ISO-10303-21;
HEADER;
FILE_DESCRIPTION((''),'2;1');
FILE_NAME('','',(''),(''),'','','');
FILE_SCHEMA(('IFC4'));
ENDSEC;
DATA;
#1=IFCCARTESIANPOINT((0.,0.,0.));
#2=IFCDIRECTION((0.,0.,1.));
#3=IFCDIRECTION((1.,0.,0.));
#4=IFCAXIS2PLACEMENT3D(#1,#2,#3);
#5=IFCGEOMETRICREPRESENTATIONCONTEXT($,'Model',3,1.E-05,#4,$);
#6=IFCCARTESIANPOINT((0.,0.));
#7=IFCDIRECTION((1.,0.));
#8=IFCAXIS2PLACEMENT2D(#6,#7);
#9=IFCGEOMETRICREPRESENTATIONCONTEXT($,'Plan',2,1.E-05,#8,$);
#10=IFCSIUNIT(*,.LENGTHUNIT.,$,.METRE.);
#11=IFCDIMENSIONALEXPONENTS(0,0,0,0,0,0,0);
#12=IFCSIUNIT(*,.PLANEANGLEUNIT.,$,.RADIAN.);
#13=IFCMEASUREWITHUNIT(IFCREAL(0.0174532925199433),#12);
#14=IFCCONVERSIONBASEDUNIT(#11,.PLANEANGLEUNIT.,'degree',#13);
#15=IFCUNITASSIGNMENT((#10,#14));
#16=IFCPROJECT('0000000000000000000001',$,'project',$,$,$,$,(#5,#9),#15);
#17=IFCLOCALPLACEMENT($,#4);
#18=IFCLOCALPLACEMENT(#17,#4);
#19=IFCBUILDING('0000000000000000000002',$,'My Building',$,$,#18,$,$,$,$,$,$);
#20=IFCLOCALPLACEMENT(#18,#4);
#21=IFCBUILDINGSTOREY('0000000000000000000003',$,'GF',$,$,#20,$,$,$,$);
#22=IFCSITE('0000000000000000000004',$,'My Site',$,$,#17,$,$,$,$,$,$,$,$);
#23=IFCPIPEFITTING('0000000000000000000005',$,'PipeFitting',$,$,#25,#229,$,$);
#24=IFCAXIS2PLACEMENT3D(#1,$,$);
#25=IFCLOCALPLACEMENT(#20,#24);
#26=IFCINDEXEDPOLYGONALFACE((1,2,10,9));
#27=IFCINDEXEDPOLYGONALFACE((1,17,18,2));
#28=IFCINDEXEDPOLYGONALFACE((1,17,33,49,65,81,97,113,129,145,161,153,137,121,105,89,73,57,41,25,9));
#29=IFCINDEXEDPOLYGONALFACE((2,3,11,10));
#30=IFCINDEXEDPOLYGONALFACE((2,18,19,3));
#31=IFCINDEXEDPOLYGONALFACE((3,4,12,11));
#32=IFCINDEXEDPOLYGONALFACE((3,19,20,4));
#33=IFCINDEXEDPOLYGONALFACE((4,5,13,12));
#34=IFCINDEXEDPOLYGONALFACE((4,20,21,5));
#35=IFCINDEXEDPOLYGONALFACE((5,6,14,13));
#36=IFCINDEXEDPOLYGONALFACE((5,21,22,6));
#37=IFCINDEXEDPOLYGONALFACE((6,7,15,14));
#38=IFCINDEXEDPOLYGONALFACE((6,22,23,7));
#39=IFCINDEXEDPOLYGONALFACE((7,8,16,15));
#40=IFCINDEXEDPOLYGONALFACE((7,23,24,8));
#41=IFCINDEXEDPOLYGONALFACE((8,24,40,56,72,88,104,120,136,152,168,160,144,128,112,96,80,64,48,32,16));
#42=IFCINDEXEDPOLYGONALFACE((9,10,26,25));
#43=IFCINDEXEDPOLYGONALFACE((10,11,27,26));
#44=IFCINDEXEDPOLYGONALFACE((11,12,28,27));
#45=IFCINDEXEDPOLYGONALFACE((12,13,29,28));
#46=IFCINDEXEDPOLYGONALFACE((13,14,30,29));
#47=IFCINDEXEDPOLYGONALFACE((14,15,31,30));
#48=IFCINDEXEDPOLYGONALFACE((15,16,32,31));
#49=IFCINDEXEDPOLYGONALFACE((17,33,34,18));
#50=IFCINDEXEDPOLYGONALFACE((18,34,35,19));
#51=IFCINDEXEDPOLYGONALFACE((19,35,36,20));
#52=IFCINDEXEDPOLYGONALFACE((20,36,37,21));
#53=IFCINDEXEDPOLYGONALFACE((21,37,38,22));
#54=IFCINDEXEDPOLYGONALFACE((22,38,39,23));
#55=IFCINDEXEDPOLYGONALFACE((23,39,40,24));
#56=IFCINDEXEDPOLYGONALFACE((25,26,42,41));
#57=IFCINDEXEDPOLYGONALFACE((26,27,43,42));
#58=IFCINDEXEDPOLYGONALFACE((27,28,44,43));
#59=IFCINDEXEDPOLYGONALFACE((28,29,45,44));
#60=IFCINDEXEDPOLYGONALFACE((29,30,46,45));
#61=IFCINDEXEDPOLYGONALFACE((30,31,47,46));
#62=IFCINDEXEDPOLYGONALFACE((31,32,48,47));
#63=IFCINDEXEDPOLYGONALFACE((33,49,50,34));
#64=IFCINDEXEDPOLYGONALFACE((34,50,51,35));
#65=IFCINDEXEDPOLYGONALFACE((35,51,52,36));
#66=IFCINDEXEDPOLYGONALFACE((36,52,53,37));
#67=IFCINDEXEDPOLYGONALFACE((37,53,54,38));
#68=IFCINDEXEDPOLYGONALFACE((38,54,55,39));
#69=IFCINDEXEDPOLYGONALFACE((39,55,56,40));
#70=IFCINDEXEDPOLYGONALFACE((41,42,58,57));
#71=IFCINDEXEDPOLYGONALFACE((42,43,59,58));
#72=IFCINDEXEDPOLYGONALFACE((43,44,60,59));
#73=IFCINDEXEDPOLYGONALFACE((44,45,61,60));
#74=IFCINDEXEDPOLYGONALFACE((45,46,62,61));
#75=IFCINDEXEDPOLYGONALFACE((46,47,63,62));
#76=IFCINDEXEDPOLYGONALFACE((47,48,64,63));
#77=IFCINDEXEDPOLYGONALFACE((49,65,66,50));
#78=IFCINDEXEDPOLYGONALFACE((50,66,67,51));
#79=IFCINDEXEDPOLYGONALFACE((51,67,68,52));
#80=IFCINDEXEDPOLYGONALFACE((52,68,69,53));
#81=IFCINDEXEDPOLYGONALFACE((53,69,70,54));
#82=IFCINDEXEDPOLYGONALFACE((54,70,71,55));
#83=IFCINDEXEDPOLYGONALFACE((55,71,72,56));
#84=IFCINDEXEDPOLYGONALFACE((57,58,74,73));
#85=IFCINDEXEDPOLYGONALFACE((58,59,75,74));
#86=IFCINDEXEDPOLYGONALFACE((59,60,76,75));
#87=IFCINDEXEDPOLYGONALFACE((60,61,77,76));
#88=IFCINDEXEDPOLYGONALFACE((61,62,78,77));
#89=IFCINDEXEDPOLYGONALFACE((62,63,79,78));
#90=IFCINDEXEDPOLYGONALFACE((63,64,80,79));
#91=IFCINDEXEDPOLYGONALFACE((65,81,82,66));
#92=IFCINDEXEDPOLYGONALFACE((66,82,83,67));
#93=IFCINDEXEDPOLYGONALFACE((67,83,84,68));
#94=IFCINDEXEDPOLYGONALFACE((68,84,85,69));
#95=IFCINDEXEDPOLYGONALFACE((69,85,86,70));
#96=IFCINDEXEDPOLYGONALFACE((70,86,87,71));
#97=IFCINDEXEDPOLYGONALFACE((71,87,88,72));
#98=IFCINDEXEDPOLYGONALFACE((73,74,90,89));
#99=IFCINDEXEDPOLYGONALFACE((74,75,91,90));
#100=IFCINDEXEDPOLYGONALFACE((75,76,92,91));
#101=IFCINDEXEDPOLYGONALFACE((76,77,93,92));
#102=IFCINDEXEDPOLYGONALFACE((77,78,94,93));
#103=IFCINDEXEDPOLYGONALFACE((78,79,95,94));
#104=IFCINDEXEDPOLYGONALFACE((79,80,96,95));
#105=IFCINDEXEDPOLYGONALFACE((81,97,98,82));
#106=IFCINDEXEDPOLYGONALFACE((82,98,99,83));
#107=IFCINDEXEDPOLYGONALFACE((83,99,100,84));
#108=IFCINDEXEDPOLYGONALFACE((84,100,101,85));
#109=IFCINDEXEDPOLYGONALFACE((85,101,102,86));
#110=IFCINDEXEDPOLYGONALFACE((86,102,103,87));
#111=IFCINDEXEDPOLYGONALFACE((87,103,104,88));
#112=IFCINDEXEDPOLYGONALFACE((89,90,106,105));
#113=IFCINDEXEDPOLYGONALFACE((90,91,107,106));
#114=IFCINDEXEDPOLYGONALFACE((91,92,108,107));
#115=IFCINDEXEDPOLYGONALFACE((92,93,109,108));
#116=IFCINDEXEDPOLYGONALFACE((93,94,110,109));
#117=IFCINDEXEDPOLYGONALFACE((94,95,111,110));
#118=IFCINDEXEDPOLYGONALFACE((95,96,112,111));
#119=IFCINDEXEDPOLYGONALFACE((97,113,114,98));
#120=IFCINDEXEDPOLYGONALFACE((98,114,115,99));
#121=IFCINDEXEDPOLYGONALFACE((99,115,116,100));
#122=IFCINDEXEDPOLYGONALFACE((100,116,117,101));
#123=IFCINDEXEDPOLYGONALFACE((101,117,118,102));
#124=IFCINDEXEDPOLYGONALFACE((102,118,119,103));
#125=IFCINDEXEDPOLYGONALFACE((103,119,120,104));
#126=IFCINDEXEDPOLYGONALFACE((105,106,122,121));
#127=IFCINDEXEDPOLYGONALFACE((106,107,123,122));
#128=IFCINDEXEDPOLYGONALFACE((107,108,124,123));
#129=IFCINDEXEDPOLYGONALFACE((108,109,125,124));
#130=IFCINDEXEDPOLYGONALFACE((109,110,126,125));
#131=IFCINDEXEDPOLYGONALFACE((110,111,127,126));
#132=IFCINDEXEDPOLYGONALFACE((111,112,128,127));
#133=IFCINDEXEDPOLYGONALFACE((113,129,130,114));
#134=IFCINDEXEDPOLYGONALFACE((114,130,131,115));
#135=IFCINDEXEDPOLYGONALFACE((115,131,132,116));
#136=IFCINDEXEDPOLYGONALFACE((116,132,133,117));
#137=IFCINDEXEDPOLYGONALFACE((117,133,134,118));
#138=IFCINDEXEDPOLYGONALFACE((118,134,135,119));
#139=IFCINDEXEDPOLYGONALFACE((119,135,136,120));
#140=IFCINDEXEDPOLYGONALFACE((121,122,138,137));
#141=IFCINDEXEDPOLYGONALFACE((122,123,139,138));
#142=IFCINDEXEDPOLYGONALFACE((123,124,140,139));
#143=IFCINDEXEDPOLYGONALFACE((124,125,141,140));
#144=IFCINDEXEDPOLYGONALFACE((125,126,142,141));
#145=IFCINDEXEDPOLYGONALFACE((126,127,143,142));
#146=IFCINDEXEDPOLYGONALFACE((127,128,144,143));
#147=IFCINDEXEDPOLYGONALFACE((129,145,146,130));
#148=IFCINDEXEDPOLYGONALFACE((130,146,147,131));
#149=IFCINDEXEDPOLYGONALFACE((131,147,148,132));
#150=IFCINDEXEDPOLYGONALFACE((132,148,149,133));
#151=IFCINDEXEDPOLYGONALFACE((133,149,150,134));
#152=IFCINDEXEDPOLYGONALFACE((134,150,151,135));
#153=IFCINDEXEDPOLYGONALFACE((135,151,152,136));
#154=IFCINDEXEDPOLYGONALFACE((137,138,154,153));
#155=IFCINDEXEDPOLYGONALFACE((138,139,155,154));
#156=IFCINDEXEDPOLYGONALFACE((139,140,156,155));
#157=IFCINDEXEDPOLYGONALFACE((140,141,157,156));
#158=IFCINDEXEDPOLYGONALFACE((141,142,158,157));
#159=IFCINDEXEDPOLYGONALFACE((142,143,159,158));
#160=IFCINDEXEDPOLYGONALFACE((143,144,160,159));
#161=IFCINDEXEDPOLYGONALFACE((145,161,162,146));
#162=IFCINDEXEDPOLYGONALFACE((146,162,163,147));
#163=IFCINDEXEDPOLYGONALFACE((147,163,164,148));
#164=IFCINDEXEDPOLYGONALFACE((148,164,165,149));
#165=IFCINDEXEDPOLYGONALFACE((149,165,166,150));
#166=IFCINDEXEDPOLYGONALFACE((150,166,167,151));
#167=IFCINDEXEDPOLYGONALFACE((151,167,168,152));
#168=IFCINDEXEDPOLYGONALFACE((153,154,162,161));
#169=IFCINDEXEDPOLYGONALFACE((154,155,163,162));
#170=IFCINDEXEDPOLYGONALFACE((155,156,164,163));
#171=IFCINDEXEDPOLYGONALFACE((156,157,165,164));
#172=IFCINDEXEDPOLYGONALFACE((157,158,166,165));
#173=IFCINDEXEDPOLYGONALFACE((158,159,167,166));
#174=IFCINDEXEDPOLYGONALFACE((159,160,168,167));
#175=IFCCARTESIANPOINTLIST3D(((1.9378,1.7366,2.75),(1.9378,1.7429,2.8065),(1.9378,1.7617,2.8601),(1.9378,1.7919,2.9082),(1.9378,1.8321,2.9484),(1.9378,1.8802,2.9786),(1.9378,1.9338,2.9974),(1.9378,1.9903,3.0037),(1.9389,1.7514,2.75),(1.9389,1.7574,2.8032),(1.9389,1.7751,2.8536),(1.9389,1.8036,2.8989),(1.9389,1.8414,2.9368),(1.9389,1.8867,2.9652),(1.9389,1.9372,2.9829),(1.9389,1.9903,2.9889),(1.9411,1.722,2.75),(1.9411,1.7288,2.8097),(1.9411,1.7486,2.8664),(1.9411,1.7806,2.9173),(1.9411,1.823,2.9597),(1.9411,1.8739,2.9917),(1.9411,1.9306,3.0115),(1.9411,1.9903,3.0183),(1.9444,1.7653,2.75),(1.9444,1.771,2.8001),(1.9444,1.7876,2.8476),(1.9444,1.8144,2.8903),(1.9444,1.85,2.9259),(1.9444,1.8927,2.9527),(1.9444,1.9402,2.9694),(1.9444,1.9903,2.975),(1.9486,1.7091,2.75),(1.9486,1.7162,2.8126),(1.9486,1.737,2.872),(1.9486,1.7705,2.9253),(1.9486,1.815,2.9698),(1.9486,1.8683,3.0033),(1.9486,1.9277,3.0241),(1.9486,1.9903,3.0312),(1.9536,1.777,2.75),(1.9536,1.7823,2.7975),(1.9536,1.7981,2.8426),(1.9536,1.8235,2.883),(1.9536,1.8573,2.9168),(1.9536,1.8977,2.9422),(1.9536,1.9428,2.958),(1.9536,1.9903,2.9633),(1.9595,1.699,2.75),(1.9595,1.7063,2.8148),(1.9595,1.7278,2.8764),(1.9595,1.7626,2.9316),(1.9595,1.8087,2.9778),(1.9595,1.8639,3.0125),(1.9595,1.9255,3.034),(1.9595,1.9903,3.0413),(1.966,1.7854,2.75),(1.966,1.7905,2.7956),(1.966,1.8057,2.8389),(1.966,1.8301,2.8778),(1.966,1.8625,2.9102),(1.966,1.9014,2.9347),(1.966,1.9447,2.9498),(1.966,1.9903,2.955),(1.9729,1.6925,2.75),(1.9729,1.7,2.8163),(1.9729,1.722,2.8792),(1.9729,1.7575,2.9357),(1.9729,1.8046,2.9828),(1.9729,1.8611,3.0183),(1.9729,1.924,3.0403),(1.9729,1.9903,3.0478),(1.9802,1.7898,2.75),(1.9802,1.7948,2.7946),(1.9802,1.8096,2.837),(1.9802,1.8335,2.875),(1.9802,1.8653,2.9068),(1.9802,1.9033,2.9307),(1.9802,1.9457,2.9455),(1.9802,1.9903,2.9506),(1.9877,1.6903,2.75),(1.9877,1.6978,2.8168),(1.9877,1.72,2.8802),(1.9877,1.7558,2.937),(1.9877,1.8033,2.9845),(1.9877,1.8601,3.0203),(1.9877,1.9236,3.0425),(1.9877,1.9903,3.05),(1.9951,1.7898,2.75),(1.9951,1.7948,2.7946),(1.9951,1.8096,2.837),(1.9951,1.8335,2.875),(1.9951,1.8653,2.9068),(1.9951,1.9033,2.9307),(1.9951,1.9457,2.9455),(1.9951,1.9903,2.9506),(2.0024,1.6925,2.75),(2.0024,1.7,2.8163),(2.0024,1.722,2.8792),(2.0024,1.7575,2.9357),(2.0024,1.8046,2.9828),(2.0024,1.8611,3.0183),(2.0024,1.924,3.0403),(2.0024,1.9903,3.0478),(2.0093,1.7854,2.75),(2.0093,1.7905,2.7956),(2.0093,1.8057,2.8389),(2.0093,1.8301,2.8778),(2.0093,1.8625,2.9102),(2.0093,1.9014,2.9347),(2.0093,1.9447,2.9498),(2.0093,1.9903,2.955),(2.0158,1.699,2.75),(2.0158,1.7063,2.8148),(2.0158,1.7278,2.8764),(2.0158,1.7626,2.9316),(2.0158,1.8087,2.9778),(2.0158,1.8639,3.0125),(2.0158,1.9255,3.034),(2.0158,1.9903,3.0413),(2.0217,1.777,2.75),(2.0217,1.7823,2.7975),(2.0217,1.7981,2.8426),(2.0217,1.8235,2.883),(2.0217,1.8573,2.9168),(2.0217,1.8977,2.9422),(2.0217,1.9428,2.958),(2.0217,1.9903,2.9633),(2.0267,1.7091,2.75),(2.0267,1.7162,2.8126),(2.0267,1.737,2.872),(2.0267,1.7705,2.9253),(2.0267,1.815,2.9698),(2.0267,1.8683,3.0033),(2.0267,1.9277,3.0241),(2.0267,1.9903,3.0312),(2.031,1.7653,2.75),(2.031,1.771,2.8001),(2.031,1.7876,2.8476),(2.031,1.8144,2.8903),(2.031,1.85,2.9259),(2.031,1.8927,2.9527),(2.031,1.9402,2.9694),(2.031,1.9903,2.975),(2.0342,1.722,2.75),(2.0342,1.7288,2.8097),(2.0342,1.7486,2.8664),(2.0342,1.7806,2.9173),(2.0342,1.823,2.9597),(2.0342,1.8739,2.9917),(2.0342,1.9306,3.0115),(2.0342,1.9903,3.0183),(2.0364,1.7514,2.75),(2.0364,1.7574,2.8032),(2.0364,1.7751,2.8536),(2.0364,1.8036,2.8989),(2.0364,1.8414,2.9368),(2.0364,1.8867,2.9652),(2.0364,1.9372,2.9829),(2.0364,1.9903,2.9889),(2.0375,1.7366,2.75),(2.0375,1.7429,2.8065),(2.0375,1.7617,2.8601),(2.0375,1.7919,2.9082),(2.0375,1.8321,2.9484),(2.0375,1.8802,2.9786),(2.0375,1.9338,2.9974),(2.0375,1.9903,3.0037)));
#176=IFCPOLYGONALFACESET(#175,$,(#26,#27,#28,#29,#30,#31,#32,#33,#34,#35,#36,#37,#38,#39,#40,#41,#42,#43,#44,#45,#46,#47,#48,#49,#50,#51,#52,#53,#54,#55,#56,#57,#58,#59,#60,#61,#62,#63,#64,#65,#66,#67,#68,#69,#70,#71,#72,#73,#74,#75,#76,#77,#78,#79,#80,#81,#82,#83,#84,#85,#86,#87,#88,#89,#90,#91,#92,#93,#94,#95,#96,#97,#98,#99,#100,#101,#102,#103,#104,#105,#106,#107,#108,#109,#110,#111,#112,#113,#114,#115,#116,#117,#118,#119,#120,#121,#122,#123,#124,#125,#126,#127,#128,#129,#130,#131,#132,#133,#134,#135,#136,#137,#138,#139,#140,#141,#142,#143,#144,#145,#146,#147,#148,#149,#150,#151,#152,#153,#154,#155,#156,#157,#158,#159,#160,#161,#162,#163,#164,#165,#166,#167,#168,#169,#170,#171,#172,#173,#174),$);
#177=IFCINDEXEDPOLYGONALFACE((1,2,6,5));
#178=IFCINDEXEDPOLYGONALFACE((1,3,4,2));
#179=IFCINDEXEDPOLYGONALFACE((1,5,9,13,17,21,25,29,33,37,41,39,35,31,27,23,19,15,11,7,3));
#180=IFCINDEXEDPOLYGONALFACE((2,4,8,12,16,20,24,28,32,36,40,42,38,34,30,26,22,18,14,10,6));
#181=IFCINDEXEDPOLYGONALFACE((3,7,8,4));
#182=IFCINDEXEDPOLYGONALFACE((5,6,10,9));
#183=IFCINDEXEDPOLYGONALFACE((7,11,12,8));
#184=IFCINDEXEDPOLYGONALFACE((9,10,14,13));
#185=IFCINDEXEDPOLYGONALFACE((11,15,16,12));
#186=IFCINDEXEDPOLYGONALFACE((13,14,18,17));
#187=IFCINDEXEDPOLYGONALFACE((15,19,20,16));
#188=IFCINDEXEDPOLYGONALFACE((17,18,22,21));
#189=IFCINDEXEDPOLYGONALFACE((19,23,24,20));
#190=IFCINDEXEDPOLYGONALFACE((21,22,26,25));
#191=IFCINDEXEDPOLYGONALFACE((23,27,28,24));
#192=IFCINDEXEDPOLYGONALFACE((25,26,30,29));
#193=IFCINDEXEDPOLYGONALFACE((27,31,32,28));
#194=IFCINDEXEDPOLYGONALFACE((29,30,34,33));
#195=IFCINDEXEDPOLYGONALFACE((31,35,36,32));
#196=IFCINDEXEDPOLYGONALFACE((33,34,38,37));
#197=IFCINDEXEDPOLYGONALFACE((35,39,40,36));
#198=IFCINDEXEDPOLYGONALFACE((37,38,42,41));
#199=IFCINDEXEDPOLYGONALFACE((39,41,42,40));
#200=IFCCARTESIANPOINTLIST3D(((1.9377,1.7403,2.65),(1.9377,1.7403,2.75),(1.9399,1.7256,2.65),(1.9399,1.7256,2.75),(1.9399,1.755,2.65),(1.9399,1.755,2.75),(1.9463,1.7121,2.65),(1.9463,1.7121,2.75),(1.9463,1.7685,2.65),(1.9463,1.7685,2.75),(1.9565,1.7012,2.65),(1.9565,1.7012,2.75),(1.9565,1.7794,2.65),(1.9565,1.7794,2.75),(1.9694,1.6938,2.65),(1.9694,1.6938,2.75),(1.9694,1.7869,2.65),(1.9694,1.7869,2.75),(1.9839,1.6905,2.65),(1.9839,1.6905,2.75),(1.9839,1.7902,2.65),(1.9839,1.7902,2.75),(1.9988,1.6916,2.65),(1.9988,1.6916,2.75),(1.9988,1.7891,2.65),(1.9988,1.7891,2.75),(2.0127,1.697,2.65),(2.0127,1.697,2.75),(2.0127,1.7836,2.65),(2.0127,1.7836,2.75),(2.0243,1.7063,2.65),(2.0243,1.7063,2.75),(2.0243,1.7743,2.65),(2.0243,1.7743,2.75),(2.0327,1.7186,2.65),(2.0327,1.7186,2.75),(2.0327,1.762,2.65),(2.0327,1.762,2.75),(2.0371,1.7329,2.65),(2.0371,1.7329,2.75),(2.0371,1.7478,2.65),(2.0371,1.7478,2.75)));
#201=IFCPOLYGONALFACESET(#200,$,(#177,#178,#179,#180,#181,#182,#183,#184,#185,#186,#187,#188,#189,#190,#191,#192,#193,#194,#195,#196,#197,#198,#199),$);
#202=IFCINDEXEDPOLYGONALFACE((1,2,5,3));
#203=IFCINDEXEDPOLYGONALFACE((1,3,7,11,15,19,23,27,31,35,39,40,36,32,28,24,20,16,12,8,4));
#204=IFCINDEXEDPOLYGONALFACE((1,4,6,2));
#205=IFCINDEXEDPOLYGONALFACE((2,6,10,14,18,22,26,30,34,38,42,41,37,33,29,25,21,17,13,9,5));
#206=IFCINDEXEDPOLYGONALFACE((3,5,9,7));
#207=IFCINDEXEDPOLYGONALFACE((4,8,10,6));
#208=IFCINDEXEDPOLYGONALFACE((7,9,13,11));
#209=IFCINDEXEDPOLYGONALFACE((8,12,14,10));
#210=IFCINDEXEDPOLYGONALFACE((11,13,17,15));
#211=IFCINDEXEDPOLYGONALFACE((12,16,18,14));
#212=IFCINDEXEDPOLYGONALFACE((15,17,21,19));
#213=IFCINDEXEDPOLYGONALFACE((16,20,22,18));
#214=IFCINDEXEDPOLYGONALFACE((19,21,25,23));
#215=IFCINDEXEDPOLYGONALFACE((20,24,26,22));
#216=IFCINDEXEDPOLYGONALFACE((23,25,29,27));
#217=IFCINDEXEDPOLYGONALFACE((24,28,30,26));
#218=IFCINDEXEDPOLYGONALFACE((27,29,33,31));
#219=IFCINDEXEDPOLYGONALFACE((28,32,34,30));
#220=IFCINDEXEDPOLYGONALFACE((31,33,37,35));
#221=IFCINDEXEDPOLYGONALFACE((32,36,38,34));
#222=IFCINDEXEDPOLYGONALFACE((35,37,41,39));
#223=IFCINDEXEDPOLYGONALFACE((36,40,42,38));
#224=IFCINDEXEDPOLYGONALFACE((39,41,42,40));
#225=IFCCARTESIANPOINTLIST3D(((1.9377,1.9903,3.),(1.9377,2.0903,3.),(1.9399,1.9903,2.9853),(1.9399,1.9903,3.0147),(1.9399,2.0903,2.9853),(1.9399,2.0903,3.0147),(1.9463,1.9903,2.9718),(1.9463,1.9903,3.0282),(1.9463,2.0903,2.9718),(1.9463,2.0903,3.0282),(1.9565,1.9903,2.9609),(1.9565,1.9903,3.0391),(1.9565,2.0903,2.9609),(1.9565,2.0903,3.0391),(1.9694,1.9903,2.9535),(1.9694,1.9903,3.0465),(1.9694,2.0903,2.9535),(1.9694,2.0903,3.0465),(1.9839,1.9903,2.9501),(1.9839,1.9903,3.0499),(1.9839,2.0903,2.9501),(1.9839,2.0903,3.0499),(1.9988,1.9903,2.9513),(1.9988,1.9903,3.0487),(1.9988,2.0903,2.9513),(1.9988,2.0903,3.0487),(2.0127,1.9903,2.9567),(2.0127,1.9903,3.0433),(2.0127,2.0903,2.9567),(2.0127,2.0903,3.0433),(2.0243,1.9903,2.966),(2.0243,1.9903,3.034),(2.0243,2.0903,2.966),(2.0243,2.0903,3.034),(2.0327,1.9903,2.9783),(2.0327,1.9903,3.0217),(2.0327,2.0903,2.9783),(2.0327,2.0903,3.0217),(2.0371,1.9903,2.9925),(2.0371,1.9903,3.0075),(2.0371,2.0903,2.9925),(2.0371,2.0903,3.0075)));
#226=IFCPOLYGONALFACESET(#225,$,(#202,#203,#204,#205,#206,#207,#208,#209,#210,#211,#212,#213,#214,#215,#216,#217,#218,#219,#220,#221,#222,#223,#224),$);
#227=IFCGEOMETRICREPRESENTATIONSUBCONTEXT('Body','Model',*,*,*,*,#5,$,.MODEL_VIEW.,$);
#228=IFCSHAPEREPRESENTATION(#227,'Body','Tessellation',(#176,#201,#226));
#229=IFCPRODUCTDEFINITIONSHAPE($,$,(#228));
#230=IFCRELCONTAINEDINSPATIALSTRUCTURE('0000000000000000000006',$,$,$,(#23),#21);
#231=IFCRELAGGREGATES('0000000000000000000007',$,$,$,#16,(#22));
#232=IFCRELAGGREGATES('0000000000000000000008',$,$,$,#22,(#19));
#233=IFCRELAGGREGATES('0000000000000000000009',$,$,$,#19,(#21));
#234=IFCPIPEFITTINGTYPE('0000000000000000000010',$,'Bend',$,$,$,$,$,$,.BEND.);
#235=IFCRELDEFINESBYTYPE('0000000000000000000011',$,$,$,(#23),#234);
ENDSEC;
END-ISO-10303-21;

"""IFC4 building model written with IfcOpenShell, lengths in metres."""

from ifc_helpers import new_model, entity, si_unit, converted_unit, frame, origin_with_axes, origin_2d_with_axis, place, context, subcontext, project, spatial, circle, extrude, source, transform, mapped, type_object, type_shapes, element, save


model = new_model("IFC4")

# Units and contexts
model_context = context("Model", 3, precision=1e-05, world=origin_with_axes())
plan_context = context("Plan", 2, precision=1e-05, world=origin_2d_with_axis())
body_context_1 = subcontext(model_context, "Body", "Model", "MODEL_VIEW")
ifc_project = project(units=[si_unit("LENGTHUNIT", "METRE"), converted_unit("PLANEANGLEUNIT", "degree", entity("IfcReal", 0.0174532925199433), si_unit("PLANEANGLEUNIT", "RADIAN"), dimensions=[0, 0, 0, 0, 0, 0, 0])], contexts=[model_context, plan_context])

# Site, building, storey
site_placement = place(None, origin_with_axes())
site = spatial("IfcSite", under=ifc_project, at=site_placement, Name="My Site")
building_placement = place(site_placement, origin_with_axes())
building = spatial("IfcBuilding", under=site, at=building_placement, Name="My Building")
storey_placement = place(building_placement, origin_with_axes())
storey = spatial("IfcBuildingStorey", under=building, at=storey_placement, Name="GF")

# Pipe fitting
pipe_fitting_type = type_object("IfcPipeFittingType", Name="Bend", PredefinedType="BEND")
shared_shape_1 = source(origin_with_axes(), body_context_1, "Body", "SolidModel", [
    entity("IfcSweptDiskSolid", entity("IfcIndexedPolyCurve", entity("IfcCartesianPointList3D", [[0.0, 0.0, -0.1], [0.0, 0.0732, -0.2768], [0.0, 0.25, -0.35]]), [entity("IfcArcIndex", [1, 2, 3])]), 0.05),
    extrude(circle(Radius=0.05), origin_with_axes(), (0.0, 0.0, -1.0), 0.1),
    extrude(circle(Radius=0.05), frame((0.0, 0.25, -0.35), z_axis=(0.0, 1.0, 0.0), x_axis=(1.0, 0.0, 0.0)), (0.0, 0.0, 1.0), 0.1),
])
type_shapes(pipe_fitting_type, [shared_shape_1])
for number, where, z_axis, x_axis, name in (
    (1, (1.9877, 1.7403, 2.65), (0.0, 0.0, -1.0), (-1.0, 0.0, 0.0), "PipeFitting"),
):
    element("IfcPipeFitting", number, at=place(storey_placement, frame(where, z_axis=z_axis, x_axis=x_axis)), inside=storey, type_object=pipe_fitting_type, Name=name, context=body_context_1, shape_type="MappedRepresentation", body=[
        mapped(shared_shape_1, transform((0.0, 0.0, 0.0), x_axis=(1.0, 0.0, 0.0), y_axis=(0.0, 1.0, 0.0), z_axis=(0.0, 0.0, 1.0), scale=1.0)),
    ])

save(model, "model.ifc")
